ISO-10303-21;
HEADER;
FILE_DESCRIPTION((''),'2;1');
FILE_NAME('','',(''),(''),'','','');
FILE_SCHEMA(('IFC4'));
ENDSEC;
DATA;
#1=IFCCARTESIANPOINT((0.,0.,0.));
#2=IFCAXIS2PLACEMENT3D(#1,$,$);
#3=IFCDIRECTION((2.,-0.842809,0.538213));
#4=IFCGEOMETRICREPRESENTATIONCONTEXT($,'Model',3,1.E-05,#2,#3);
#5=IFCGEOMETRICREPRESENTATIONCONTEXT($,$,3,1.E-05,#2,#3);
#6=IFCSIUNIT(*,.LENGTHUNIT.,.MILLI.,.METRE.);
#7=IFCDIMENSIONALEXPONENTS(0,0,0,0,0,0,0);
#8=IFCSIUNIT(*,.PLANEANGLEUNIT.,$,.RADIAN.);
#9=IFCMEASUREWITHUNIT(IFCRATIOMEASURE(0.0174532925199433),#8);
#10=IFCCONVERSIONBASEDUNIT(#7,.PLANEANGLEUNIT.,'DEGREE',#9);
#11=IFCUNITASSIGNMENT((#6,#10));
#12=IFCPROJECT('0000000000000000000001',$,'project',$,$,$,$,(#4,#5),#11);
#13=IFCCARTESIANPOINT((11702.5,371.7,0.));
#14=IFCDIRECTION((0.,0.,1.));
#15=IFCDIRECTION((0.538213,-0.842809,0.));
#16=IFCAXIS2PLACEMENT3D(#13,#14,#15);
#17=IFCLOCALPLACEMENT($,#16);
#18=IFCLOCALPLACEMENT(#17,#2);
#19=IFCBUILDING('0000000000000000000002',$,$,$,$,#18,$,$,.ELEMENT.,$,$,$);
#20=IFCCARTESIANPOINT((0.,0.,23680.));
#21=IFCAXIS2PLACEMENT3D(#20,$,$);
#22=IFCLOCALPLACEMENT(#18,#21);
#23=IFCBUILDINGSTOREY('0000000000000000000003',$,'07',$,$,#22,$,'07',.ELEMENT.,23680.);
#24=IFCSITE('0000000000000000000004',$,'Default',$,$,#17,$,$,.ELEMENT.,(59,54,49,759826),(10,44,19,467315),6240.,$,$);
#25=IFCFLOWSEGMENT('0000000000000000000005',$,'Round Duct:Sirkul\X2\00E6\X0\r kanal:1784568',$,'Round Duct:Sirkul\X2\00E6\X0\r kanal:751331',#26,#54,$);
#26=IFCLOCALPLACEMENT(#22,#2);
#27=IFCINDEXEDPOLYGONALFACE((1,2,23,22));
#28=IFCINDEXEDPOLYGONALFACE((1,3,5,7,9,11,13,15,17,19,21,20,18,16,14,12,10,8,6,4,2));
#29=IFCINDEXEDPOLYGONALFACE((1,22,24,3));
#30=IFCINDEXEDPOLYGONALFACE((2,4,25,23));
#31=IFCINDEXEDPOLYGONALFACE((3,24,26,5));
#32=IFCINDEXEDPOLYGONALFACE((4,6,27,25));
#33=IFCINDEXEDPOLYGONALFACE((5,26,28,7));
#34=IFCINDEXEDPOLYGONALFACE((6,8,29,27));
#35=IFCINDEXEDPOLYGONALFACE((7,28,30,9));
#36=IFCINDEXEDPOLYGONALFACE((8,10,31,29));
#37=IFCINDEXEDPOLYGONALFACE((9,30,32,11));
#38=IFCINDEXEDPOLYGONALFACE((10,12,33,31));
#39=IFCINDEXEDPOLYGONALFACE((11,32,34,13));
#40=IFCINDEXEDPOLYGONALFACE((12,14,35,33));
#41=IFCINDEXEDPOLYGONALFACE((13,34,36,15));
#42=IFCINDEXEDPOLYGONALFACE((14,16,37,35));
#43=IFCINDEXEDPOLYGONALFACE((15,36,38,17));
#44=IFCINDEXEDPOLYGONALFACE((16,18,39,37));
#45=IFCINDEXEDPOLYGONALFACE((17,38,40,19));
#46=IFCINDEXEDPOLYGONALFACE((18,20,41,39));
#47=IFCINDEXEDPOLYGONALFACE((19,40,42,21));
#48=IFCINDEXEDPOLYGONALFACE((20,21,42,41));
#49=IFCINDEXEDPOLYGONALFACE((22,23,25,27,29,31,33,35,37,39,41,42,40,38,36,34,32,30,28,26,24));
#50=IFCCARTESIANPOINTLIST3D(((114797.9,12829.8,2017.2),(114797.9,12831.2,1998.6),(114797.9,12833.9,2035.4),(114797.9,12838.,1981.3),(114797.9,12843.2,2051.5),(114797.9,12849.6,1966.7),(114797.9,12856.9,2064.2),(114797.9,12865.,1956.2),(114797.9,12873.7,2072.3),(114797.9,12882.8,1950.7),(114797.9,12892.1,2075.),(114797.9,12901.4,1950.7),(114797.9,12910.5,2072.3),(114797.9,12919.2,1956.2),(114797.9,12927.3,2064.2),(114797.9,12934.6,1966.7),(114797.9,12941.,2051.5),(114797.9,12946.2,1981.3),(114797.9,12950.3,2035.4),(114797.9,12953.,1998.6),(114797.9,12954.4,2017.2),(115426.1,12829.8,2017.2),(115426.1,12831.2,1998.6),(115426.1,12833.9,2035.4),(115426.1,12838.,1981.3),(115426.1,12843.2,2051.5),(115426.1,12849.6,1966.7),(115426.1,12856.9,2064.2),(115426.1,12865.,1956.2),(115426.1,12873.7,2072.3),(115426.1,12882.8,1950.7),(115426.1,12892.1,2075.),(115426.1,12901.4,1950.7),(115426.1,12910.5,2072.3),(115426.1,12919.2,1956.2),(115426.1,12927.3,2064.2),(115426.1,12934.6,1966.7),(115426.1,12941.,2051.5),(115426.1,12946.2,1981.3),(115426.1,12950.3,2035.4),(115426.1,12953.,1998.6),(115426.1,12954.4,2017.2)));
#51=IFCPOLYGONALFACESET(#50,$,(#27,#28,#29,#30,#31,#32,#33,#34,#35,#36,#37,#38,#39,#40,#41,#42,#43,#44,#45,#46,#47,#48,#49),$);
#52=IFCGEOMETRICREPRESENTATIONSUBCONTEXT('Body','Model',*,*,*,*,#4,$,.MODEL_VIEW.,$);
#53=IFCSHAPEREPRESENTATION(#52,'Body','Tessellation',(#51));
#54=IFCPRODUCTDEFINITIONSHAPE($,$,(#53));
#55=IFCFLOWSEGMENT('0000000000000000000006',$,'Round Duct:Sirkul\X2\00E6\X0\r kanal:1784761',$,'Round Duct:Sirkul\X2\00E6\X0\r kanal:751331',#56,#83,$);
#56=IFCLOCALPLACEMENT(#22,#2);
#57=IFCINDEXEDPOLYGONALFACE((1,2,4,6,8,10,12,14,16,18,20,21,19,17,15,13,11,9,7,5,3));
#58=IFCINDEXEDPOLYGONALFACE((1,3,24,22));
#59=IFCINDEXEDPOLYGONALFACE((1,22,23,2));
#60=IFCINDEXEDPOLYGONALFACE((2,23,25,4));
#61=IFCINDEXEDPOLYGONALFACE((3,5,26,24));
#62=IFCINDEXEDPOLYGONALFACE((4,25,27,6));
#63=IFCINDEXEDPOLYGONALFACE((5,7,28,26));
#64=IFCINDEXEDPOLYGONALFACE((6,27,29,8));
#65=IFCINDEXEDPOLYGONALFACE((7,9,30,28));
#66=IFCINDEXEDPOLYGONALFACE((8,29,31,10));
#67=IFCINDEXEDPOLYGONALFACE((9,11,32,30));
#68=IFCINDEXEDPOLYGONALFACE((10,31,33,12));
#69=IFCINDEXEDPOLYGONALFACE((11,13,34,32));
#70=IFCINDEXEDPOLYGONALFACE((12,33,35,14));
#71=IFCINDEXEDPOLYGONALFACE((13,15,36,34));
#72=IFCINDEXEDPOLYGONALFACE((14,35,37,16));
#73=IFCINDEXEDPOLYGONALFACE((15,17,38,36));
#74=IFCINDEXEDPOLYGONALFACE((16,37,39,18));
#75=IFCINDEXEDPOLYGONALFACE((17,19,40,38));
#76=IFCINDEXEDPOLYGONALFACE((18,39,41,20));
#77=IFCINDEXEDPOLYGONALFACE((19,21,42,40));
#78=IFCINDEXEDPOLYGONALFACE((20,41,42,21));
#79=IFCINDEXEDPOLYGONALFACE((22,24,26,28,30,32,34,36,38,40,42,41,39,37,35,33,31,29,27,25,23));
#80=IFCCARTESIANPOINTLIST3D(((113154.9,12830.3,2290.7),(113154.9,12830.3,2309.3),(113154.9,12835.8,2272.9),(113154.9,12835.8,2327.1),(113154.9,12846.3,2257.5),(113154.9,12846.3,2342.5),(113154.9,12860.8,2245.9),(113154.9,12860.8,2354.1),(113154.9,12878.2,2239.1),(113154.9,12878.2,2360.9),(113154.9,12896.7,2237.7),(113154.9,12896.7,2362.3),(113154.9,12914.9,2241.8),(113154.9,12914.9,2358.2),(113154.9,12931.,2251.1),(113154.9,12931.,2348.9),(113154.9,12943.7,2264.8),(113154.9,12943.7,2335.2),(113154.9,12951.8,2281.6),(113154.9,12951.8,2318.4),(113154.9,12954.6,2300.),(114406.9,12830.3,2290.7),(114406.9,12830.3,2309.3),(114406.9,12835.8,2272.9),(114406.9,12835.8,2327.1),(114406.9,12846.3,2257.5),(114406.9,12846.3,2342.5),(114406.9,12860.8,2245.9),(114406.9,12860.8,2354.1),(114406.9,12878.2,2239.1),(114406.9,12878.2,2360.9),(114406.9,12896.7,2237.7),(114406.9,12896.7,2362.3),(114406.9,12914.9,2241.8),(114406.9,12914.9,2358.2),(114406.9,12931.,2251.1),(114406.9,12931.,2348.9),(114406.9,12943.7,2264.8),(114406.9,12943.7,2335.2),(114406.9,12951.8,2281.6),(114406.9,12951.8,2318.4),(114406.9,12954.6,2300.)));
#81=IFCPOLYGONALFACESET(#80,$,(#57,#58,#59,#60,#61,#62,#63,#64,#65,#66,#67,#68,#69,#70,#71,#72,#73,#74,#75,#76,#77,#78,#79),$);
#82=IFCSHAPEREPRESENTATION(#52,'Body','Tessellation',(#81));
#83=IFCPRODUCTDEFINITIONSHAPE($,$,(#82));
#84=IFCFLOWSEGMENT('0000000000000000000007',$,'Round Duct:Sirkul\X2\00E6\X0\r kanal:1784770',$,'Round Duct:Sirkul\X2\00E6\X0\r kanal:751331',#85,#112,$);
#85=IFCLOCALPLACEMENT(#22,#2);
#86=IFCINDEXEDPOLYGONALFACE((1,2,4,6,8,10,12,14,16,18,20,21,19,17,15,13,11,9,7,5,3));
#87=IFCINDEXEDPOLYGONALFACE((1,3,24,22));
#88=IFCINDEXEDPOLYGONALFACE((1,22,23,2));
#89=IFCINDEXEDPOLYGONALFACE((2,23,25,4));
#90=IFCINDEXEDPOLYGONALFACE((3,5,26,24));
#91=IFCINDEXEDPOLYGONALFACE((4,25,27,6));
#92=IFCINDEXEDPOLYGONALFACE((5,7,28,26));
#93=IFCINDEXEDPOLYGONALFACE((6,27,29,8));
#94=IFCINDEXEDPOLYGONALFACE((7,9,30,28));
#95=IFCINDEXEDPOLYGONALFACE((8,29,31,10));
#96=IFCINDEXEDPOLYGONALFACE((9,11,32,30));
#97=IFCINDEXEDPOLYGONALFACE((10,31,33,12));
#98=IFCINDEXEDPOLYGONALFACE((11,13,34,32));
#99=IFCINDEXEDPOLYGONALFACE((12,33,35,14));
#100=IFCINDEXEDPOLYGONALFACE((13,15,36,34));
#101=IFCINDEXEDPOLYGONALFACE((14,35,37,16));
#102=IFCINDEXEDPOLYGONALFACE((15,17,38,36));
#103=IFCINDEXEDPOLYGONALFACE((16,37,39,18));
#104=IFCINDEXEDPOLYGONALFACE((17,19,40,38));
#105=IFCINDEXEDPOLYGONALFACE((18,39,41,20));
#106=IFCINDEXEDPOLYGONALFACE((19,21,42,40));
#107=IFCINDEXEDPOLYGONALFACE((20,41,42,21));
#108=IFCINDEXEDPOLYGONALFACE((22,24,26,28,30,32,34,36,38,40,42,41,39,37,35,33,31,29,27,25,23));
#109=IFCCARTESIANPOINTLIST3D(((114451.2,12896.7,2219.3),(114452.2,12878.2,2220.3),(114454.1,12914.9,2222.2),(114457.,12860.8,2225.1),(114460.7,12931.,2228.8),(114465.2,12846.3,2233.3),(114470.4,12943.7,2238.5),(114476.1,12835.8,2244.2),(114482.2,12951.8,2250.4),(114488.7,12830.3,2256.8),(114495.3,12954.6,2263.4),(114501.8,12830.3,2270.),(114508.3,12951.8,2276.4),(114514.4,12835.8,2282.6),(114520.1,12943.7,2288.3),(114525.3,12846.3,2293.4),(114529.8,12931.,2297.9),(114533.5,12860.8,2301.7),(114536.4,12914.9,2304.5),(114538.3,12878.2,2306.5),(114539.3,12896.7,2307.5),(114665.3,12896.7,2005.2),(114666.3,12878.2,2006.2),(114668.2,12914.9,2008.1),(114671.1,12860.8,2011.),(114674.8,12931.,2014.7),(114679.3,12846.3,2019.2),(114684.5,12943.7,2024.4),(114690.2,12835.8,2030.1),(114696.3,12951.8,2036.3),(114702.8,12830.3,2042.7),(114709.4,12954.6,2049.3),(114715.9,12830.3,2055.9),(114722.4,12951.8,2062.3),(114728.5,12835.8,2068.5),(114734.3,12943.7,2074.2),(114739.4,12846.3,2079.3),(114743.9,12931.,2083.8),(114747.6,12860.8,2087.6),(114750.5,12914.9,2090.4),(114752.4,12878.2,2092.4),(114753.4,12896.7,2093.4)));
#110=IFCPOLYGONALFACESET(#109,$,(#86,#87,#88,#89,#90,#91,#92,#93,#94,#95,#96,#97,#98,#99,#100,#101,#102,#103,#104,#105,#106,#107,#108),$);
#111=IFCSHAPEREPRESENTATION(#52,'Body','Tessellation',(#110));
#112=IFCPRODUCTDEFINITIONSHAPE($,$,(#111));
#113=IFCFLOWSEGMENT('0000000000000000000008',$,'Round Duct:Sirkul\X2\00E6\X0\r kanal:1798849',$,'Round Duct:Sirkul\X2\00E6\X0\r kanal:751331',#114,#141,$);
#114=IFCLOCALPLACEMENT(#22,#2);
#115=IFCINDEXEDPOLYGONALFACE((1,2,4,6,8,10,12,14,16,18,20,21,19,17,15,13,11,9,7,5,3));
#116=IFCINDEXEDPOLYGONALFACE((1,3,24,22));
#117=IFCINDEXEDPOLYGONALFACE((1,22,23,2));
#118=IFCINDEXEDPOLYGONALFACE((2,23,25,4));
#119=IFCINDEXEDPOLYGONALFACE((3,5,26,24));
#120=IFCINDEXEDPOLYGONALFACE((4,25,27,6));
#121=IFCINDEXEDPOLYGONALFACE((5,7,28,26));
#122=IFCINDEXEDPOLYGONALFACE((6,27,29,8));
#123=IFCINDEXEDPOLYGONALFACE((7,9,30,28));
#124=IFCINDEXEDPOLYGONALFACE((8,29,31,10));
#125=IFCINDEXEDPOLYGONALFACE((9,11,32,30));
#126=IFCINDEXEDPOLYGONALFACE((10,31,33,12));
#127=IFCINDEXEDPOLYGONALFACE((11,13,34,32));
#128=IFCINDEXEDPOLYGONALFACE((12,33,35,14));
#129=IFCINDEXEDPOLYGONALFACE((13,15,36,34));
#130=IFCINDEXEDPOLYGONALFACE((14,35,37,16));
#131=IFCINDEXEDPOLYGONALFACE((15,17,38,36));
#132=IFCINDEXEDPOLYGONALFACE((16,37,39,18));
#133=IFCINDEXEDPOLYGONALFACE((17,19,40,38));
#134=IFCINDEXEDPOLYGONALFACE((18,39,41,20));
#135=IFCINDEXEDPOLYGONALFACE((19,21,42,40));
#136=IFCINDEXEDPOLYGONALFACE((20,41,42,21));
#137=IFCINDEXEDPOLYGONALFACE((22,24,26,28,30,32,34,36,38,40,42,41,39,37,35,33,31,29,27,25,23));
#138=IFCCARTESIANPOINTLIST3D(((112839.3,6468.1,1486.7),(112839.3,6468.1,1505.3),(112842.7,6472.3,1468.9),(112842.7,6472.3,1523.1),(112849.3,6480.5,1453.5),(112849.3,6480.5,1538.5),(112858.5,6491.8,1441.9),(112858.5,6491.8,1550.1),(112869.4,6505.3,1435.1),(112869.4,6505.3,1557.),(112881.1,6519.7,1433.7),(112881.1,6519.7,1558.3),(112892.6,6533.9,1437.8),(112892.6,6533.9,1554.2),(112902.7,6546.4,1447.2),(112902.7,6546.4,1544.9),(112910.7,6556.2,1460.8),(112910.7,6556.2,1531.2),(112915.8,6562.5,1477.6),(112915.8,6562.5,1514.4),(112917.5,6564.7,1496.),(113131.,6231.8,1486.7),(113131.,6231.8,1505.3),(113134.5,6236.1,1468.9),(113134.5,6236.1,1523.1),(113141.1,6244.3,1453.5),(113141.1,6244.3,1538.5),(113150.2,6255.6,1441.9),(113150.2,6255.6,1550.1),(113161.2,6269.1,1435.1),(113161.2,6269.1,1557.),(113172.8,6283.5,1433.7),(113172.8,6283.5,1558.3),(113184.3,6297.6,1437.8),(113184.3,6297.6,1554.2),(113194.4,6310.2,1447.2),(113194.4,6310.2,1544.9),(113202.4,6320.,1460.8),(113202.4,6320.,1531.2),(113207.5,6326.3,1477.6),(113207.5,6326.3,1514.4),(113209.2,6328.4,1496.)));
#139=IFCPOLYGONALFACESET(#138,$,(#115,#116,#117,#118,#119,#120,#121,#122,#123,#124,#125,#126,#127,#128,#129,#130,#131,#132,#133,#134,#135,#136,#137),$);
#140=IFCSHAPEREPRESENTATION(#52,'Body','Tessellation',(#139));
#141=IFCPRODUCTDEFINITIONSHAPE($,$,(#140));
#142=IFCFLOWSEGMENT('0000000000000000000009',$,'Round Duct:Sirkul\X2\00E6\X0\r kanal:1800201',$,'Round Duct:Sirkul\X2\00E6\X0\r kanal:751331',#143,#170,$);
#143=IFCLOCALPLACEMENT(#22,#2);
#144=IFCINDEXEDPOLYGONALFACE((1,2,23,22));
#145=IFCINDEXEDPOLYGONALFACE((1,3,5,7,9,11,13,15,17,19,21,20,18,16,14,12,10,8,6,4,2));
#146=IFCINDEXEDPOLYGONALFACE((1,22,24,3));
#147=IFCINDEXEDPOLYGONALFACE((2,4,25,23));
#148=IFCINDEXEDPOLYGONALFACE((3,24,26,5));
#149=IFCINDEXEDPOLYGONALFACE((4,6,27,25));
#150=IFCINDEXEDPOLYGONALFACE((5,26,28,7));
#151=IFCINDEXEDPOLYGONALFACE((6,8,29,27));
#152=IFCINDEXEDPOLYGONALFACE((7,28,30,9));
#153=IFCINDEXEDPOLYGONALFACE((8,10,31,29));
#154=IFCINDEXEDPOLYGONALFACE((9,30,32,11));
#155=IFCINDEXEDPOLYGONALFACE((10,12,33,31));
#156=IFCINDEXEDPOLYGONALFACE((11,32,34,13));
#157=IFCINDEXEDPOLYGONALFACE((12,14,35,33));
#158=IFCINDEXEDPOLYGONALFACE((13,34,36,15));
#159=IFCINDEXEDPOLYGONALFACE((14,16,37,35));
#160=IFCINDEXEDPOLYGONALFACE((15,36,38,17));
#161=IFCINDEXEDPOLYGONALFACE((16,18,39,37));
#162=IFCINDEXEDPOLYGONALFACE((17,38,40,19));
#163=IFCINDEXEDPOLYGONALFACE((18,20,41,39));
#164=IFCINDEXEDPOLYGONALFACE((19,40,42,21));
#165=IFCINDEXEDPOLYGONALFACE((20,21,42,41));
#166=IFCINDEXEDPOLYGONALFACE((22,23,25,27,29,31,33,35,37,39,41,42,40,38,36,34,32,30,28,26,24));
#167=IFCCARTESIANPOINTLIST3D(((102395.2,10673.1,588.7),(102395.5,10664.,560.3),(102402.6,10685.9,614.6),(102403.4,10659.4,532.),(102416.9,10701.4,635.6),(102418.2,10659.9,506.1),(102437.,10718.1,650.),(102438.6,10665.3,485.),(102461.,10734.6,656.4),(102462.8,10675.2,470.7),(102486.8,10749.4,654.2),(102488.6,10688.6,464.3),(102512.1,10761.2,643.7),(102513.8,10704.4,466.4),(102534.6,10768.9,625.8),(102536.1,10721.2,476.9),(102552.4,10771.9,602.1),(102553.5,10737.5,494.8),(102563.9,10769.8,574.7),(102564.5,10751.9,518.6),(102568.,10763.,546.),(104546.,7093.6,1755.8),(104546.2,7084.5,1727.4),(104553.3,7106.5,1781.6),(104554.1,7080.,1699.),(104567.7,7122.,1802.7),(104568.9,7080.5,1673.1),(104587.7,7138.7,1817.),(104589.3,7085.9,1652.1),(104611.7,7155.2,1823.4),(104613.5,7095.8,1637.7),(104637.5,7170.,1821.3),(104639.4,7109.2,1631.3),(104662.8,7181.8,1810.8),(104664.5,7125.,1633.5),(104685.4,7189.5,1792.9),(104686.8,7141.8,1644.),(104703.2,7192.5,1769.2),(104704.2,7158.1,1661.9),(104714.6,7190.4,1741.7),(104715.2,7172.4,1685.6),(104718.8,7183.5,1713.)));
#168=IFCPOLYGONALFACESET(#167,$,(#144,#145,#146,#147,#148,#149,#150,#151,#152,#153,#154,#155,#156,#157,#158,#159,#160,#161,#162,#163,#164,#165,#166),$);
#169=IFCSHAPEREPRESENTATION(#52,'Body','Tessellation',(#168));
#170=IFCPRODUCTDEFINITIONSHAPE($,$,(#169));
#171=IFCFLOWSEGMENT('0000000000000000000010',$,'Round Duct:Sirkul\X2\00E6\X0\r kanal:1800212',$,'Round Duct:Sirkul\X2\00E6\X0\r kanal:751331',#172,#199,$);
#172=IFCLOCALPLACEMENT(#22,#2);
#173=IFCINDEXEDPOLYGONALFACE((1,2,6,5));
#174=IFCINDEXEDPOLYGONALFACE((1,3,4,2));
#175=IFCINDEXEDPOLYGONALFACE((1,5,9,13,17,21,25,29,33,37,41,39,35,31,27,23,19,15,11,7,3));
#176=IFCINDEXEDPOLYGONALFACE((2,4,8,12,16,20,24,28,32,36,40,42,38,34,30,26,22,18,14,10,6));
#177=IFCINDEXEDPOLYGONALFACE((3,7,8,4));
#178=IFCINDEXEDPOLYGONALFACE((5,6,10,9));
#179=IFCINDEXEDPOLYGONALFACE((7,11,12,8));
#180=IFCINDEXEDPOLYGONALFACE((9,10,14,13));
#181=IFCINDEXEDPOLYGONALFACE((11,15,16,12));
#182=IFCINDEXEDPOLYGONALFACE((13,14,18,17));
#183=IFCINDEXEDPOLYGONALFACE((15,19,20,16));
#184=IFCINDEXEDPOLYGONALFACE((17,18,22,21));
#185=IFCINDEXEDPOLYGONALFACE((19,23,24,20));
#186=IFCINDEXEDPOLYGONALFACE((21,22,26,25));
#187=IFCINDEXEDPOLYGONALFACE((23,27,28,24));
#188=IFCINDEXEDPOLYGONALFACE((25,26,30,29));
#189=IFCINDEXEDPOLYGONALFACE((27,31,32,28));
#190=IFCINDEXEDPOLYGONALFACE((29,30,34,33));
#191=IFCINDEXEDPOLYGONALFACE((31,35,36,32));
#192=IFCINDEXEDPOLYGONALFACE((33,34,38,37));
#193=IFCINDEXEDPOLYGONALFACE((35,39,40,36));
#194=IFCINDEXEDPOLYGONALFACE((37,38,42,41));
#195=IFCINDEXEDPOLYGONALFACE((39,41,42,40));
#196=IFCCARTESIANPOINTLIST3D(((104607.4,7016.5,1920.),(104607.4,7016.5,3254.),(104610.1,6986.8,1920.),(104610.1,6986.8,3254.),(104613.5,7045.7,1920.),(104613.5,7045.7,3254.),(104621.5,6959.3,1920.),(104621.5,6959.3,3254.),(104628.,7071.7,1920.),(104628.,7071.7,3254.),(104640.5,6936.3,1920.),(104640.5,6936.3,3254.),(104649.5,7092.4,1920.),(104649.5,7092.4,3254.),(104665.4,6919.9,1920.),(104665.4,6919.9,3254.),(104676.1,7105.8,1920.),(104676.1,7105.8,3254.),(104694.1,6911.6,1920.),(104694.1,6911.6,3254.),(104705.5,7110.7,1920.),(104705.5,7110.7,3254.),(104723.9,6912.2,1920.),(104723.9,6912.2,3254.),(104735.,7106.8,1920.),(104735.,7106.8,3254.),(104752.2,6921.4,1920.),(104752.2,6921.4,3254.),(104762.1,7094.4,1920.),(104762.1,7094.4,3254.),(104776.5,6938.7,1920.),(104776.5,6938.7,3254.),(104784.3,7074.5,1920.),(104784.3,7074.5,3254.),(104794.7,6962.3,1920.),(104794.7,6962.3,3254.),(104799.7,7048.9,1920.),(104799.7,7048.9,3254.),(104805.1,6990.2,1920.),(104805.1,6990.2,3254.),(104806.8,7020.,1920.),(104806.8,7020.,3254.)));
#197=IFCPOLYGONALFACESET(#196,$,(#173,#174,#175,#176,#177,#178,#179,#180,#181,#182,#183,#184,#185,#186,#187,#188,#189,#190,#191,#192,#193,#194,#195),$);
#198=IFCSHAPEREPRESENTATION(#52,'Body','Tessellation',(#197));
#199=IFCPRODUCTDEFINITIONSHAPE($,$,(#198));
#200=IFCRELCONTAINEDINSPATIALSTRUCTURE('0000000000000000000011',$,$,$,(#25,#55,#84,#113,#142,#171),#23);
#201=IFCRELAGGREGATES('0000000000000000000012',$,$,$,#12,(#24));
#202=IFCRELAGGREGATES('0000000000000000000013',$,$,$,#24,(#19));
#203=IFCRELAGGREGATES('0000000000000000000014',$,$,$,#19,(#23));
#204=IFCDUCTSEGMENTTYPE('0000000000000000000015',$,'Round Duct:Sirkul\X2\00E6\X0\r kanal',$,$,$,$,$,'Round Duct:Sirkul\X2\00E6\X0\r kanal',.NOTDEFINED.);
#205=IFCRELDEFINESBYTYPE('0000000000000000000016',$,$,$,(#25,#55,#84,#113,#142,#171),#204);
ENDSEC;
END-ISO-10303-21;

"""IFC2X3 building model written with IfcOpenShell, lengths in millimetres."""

from ifc_helpers import new_model, entity, si_unit, converted_unit, direction, frame, frame_2d, origin, origin_2d_with_axis, place, context, subcontext, project, spatial, circle, extrude, type_object, element, save


model = new_model("IFC2X3")

# Units and contexts
model_context = context("Model", 3, precision=1e-05, world=origin(), true_north=direction((2.0, -0.842809, 0.538213)))
context_of_model = context(None, 3, precision=1e-05, world=origin(), true_north=direction((2.0, -0.842809, 0.538213)))
body_context = subcontext(model_context, "Body", "Model", "MODEL_VIEW")
ifc_project = project(units=[si_unit("LENGTHUNIT", "METRE", prefix="MILLI"), converted_unit("PLANEANGLEUNIT", "DEGREE", entity("IfcRatioMeasure", 0.0174532925199433), si_unit("PLANEANGLEUNIT", "RADIAN"), dimensions=[0, 0, 0, 0, 0, 0, 0])], contexts=[model_context, context_of_model])

# Site, building, storey
site_placement = place(None, frame((11702.5, 371.7, 0.0), z_axis=(0.0, 0.0, 1.0), x_axis=(0.538213, -0.842809, 0.0)))
site = spatial("IfcSite", under=ifc_project, at=site_placement, Name="Default", CompositionType="ELEMENT", RefLatitude=(59, 54, 49, 759826), RefLongitude=(10, 44, 19, 467315), RefElevation=6240.0)
building_placement = place(site_placement, origin())
building = spatial("IfcBuilding", under=site, at=building_placement, CompositionType="ELEMENT")
storey_placement = place(building_placement, frame((0.0, 0.0, 23680.0)))
storey = spatial("IfcBuildingStorey", under=building, at=storey_placement, Name="07", LongName="07", CompositionType="ELEMENT", Elevation=23680.0)

# Flow segments
duct_segment_type = type_object("IfcDuctSegmentType", Name="Round Duct:Sirkulær kanal", ElementType="Round Duct:Sirkulær kanal", PredefinedType="NOTDEFINED")
flow_segment_1_placement = place(storey_placement, origin())
element("IfcFlowSegment", 1, at=flow_segment_1_placement, inside=storey, type_object=duct_segment_type, Name="Round Duct:Sirkulær kanal:1784568", ObjectType="Round Duct:Sirkulær kanal:751331", context=body_context, shape_type="SweptSolid", body=[
    extrude(circle(Radius=62.5, at=frame_2d((0.0, 0.0), x_axis=(1.0, 0.0))), frame((114797.9, 12892.1, 2012.5), z_axis=(1.0, 0.0, 0.0), x_axis=(0.0, 0.0, 1.0)), (0.0, 0.0, 1.0), 628.2),
])
flow_segment_2_placement = place(storey_placement, origin())
element("IfcFlowSegment", 2, at=flow_segment_2_placement, inside=storey, type_object=duct_segment_type, Name="Round Duct:Sirkulær kanal:1784761", ObjectType="Round Duct:Sirkulær kanal:751331", context=body_context, shape_type="SweptSolid", body=[
    extrude(circle(Radius=62.5, at=origin_2d_with_axis()), frame((113154.9, 12892.1, 2300.0), z_axis=(1.0, 0.0, 0.0), x_axis=(0.0, 1.0, 0.0)), (0.0, 0.0, 1.0), 1251.9),
])
flow_segment_3_placement = place(storey_placement, origin())
element("IfcFlowSegment", 3, at=flow_segment_3_placement, inside=storey, type_object=duct_segment_type, Name="Round Duct:Sirkulær kanal:1784770", ObjectType="Round Duct:Sirkulær kanal:751331", context=body_context, shape_type="SweptSolid", body=[
    extrude(circle(Radius=62.5, at=frame_2d((0.0, 0.0), x_axis=(1.0, 0.0))), frame((114709.4, 12892.1, 2049.3), z_axis=(-0.707107, 0.0, 0.707107), x_axis=(0.0, 1.0, 0.0)), (0.0, 0.0, 1.0), 302.8),
])
flow_segment_4_placement = place(storey_placement, origin())
element("IfcFlowSegment", 4, at=flow_segment_4_placement, inside=storey, type_object=duct_segment_type, Name="Round Duct:Sirkulær kanal:1798849", ObjectType="Round Duct:Sirkulær kanal:751331", context=body_context, shape_type="SweptSolid", body=[
    extrude(circle(Radius=62.5, at=frame_2d((0.0, 0.0), x_axis=(1.0, 0.0))), frame((113169.9, 6279.9, 1496.0), z_axis=(-0.777146, 0.62932, 0.0), x_axis=(0.62932, 0.777146, 0.0)), (0.0, 0.0, 1.0), 375.4),
])
flow_segment_5_placement = place(storey_placement, origin())
element("IfcFlowSegment", 5, at=flow_segment_5_placement, inside=storey, type_object=duct_segment_type, Name="Round Duct:Sirkulær kanal:1800201", ObjectType="Round Duct:Sirkulær kanal:751331", context=body_context, shape_type="SweptSolid", body=[
    extrude(circle(Radius=100.0, at=origin_2d_with_axis()), frame((102481.2, 10715.5, 560.3), z_axis=(0.496031, -0.825535, 0.269156), x_axis=(-0.857167, -0.515038, 0.0)), (0.0, 0.0, 1.0), 4335.9),
])
flow_segment_6_placement = place(storey_placement, origin())
element("IfcFlowSegment", 6, at=flow_segment_6_placement, inside=storey, type_object=duct_segment_type, Name="Round Duct:Sirkulær kanal:1800212", ObjectType="Round Duct:Sirkulær kanal:751331", context=body_context, shape_type="SweptSolid", body=[
    extrude(circle(Radius=100.0, at=frame_2d((0.0, 0.0), x_axis=(1.0, 0.0))), frame((104707.2, 7010.8, 1920.0), z_axis=(0.0, 0.0, 1.0), x_axis=(-0.857167, -0.515038, 0.0)), (0.0, 0.0, 1.0), 1334.0),
])

save(model, "model.ifc")
